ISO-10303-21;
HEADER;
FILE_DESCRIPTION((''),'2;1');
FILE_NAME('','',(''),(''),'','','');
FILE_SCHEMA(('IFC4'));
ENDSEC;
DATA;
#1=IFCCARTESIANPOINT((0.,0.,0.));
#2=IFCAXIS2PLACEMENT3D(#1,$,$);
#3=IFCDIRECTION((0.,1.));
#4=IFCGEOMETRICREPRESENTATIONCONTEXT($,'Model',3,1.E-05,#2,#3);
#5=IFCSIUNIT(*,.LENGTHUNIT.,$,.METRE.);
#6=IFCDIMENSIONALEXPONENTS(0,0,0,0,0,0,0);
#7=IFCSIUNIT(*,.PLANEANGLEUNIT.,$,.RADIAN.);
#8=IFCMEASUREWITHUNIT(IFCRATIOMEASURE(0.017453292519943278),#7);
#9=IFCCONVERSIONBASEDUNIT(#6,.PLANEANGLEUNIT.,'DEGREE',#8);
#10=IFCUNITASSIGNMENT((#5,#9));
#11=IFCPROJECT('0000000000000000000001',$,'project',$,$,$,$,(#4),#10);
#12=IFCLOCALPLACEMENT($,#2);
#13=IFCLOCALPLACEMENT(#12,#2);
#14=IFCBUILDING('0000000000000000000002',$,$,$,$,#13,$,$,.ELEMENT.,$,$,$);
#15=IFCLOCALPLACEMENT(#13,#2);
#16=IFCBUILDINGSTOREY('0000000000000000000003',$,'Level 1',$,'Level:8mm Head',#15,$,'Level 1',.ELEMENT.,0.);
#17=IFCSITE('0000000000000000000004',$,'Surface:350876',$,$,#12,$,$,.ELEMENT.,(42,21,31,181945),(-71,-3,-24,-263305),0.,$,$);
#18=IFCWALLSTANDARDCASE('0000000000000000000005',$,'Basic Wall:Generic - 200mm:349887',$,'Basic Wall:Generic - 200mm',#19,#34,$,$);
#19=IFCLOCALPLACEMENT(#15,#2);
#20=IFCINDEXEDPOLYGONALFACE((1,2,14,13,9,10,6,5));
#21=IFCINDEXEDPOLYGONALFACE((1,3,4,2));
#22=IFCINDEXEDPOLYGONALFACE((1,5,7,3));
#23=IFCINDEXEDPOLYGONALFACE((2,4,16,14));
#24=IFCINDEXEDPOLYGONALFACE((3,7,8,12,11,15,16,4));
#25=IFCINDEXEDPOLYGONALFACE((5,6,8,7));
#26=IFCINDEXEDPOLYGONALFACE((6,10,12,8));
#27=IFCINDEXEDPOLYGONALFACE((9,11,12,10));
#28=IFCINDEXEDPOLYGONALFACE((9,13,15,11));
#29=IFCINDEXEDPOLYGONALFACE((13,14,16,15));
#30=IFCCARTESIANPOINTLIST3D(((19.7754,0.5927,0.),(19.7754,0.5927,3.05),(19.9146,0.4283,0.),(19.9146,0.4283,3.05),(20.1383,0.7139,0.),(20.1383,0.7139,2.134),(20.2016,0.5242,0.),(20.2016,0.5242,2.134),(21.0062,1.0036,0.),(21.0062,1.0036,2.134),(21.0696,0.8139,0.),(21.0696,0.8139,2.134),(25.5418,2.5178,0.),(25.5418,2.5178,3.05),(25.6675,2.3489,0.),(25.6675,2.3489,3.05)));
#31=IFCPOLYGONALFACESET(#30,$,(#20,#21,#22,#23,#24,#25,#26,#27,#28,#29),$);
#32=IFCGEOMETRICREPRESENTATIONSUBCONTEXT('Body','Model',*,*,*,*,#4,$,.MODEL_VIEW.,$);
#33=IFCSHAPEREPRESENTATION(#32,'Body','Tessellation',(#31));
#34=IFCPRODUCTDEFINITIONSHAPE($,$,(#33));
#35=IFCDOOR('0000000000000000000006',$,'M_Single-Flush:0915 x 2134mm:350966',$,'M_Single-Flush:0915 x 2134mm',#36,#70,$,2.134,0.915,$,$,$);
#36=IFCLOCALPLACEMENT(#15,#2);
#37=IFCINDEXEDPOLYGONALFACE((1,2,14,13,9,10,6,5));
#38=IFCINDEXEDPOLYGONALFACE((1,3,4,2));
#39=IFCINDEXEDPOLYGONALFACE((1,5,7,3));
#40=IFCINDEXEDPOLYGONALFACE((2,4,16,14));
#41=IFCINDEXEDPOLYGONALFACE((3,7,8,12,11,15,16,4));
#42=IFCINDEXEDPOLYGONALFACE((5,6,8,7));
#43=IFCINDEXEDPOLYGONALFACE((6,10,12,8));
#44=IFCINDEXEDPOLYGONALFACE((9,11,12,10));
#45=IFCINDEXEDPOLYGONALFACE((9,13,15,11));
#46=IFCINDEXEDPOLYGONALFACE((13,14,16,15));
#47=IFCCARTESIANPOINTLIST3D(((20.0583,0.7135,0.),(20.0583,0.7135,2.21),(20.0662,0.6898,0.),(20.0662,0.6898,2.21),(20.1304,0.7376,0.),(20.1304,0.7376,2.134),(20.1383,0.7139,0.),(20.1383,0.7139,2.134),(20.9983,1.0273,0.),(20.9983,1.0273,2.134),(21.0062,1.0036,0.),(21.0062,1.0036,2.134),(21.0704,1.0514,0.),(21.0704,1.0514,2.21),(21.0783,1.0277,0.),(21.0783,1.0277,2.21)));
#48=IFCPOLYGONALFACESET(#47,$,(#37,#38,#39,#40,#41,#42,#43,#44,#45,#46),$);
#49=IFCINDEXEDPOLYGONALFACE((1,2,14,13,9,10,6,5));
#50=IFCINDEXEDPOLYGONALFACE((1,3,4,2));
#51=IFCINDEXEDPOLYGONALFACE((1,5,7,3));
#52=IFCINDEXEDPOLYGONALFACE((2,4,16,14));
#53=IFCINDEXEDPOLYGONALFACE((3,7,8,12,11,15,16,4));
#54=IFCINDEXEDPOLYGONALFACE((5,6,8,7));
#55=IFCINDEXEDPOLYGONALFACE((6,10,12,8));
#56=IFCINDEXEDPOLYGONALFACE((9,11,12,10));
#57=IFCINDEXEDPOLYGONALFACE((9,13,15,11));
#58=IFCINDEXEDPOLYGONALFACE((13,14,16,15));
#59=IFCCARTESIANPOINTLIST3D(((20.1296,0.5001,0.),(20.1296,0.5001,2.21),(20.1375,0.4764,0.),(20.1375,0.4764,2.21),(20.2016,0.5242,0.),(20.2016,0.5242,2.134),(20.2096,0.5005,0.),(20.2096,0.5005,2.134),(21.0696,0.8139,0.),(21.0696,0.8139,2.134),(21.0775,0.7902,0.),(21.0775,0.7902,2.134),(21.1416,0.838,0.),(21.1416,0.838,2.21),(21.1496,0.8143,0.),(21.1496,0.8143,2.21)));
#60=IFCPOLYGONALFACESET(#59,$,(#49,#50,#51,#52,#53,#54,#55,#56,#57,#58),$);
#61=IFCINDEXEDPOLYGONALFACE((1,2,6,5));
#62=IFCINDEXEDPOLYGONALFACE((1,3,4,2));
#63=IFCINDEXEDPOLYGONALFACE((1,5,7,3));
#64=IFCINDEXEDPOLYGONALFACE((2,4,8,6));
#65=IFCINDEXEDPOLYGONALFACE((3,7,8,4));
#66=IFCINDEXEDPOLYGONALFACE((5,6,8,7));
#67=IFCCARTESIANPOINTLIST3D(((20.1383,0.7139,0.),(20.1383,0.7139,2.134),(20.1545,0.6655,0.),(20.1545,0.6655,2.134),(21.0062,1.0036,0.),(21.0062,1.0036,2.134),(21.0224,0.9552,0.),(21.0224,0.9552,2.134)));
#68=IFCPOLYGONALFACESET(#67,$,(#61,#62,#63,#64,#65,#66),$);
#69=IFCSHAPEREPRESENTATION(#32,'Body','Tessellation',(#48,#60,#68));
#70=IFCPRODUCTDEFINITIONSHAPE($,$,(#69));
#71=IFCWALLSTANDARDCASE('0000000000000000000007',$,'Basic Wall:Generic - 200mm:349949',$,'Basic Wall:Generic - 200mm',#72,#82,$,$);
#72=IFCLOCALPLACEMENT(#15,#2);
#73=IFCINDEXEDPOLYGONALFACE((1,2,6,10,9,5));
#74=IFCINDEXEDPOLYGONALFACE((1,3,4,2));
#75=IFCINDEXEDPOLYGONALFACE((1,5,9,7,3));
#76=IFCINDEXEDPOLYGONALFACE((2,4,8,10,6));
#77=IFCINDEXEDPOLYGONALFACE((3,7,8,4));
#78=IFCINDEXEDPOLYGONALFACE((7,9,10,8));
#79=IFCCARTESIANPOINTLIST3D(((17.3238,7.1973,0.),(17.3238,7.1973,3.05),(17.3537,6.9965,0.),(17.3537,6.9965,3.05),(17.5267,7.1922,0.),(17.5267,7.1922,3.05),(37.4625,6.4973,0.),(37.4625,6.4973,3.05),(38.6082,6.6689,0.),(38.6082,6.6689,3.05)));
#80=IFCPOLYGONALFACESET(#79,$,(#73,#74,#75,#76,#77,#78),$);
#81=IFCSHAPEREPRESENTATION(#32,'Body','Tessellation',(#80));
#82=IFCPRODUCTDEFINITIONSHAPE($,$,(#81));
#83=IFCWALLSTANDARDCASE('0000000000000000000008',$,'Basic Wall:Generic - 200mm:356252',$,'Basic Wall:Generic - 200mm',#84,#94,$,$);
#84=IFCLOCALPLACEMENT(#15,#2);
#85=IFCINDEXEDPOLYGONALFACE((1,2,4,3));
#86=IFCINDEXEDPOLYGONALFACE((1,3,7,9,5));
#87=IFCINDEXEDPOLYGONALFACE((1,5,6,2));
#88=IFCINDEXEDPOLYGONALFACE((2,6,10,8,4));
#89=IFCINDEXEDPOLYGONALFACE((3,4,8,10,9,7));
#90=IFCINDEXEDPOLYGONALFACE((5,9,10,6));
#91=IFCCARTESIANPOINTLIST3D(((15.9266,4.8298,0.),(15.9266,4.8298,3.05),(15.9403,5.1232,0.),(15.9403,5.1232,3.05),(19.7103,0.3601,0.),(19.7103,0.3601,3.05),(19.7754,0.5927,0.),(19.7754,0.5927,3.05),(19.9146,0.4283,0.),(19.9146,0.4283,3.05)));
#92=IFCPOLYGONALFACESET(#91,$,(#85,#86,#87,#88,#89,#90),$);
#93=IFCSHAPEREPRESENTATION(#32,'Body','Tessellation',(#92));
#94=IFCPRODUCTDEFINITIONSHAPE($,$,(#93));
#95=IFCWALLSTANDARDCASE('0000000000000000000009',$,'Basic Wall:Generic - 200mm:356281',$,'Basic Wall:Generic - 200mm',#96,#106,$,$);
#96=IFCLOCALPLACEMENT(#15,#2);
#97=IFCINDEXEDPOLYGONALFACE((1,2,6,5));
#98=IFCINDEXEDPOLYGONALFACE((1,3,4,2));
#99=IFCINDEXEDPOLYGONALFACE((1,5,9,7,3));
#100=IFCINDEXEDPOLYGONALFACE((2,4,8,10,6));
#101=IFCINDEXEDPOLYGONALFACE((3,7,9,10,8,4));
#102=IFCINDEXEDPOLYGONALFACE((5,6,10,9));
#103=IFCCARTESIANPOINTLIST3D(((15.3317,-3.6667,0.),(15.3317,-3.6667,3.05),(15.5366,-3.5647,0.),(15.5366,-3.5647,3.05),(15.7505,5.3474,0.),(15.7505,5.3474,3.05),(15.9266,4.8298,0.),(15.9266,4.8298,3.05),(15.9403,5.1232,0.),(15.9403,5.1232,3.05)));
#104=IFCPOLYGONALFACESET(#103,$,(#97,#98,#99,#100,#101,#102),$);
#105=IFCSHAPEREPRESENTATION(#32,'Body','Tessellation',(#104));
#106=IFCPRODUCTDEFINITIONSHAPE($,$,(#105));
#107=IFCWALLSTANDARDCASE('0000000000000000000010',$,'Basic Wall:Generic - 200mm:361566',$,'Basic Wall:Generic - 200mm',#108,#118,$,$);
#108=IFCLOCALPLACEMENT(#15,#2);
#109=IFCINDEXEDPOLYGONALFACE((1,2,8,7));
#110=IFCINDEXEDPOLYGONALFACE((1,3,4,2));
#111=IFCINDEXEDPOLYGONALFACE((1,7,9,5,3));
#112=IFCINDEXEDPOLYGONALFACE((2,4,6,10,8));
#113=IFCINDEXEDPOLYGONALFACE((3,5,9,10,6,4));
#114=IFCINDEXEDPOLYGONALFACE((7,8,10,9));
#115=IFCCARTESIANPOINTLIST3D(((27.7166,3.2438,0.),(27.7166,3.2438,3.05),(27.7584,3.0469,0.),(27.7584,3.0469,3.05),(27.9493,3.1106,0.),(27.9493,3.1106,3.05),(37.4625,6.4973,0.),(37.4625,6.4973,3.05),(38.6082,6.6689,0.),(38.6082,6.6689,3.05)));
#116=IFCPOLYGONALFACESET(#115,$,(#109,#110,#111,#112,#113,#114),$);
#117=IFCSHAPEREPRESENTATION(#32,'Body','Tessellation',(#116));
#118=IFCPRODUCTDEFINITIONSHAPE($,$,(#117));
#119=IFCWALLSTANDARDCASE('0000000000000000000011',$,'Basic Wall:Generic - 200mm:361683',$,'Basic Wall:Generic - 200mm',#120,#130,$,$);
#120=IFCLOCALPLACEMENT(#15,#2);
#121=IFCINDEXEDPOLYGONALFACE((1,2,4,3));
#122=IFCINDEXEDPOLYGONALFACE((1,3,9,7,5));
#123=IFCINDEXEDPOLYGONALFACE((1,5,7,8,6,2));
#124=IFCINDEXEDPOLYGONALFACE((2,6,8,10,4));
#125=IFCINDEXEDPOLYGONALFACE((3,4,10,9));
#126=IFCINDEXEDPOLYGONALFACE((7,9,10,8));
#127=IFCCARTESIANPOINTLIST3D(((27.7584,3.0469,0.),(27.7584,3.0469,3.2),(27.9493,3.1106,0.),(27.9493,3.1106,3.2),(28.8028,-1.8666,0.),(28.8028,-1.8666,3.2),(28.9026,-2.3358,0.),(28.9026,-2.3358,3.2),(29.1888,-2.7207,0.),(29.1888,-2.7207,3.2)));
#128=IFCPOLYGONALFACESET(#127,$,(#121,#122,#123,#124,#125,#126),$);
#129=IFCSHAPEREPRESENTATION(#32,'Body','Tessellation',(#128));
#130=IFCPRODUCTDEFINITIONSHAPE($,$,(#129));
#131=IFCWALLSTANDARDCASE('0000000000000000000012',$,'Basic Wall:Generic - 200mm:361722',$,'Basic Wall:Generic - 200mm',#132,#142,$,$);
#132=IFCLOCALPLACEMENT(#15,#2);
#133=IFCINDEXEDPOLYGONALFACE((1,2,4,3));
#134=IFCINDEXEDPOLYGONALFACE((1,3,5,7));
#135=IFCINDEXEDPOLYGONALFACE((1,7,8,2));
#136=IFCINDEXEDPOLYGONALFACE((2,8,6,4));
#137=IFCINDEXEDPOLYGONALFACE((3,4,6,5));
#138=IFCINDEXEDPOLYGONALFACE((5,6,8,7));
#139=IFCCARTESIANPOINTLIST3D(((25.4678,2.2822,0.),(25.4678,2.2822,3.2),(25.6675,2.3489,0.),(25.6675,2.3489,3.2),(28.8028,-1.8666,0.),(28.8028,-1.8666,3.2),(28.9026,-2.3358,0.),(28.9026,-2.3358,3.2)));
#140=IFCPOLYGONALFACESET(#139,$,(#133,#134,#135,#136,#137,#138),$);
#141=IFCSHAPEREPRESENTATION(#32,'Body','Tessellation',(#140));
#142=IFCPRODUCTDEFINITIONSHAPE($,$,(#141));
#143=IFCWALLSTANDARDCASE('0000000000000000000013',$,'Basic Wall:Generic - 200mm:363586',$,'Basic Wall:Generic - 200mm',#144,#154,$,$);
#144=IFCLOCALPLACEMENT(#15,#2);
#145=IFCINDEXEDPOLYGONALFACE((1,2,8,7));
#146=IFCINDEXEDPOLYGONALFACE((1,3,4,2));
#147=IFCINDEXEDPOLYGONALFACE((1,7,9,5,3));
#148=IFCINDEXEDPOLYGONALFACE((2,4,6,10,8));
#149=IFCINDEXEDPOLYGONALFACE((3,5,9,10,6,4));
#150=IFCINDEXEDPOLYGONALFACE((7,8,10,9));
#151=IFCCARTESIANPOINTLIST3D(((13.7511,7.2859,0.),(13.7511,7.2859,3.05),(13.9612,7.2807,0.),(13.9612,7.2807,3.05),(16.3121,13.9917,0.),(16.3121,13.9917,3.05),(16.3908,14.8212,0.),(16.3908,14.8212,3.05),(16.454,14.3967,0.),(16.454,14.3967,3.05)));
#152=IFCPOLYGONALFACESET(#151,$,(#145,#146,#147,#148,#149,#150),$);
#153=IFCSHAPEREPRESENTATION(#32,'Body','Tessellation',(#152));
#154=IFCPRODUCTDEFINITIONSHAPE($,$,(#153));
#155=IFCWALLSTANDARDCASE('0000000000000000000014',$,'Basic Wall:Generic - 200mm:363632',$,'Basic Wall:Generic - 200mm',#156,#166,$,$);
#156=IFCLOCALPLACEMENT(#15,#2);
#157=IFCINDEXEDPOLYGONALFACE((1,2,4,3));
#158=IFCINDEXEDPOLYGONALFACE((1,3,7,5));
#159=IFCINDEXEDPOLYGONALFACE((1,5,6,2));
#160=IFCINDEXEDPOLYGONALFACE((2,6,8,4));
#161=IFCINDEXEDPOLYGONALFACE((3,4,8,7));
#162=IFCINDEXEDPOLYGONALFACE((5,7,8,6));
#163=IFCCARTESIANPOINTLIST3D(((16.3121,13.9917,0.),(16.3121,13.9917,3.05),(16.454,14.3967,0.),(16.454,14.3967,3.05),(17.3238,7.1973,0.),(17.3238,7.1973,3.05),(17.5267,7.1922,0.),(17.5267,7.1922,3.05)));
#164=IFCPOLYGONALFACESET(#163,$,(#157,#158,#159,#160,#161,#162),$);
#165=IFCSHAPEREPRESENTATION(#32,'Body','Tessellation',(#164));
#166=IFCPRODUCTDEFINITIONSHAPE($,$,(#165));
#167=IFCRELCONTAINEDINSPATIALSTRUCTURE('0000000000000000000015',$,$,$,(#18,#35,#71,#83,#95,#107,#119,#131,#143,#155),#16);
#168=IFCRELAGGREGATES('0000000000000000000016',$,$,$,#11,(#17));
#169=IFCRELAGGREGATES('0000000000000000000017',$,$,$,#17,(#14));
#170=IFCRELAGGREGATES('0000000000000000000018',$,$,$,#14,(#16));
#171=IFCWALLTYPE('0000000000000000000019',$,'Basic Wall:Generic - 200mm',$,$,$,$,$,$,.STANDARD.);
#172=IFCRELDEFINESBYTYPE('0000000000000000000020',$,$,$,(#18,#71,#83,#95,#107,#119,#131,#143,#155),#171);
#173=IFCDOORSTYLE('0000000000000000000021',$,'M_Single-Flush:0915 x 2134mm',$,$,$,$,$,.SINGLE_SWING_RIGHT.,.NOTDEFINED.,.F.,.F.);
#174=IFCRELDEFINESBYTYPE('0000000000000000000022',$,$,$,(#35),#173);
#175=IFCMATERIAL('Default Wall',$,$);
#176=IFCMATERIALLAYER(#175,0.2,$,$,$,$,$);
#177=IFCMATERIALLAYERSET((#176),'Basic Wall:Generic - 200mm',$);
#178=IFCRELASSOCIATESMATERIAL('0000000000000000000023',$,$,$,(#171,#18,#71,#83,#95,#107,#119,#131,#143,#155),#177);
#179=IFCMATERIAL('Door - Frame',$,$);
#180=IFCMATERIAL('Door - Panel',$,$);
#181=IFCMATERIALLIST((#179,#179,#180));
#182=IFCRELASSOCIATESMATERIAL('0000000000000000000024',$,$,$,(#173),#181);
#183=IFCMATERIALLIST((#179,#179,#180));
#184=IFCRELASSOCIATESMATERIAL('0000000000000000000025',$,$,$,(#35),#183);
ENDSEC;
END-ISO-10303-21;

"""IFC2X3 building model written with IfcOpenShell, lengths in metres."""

from ifc_helpers import new_model, entity, si_unit, converted_unit, direction, frame, frame_2d, origin, place, context, subcontext, project, spatial, polyline, rectangle, outline, extrude, source, transform, mapped, material, material_list, layer, layer_set, layer_usage, type_object, type_shapes, element, fill, save


model = new_model("IFC2X3")

# Units and contexts
model_context = context("Model", 3, precision=1e-05, world=origin(), true_north=direction((0.0, 1.0)))
body_context = subcontext(model_context, "Body", "Model", "MODEL_VIEW")
ifc_project = project(units=[si_unit("LENGTHUNIT", "METRE"), converted_unit("PLANEANGLEUNIT", "DEGREE", entity("IfcRatioMeasure", 0.017453292519943278), si_unit("PLANEANGLEUNIT", "RADIAN"), dimensions=[0, 0, 0, 0, 0, 0, 0])], contexts=[model_context])

# Site, building, storey
site_placement = place(None, origin())
site = spatial("IfcSite", under=ifc_project, at=site_placement, Name="Surface:350876", CompositionType="ELEMENT", RefLatitude=(42, 21, 31, 181945), RefLongitude=(-71, -3, -24, -263305), RefElevation=0.0)
building_placement = place(site_placement, origin())
building = spatial("IfcBuilding", under=site, at=building_placement, CompositionType="ELEMENT")
storey_placement = place(building_placement, origin())
storey = spatial("IfcBuildingStorey", under=building, at=storey_placement, Name="Level 1", ObjectType="Level:8mm Head", LongName="Level 1", CompositionType="ELEMENT", Elevation=0.0)

# Wall, opening, door
ifc_material_1 = material(Name="Default Wall")
ifc_layer_1 = layer(ifc_material_1, 0.2)
ifc_layer_set_1 = layer_set([ifc_layer_1], Name="Basic Wall:Generic - 200mm")
ifc_layer_usage_1 = layer_usage(ifc_layer_set_1, "AXIS2", "NEGATIVE", 0.1)
wall_type_1 = type_object("IfcWallType", Name="Basic Wall:Generic - 200mm", PredefinedType="STANDARD", material=ifc_layer_set_1)
wall_1_placement = place(storey_placement, frame((19.8071, 0.4979, 0.0), z_axis=(0.0, 0.0, 1.0), x_axis=(0.94854, 0.316657, 0.0)))
wall_1 = element("IfcWallStandardCase", 1, at=wall_1_placement, inside=storey, type_object=wall_type_1, material=ifc_layer_usage_1, Name="Basic Wall:Generic - 200mm:349887", ObjectType="Basic Wall:Generic - 200mm", context=body_context, shape_type="SweptSolid", body=[
    extrude(outline(polyline([(0.0799, -0.1), (6.1449, -0.1), (6.0792, 0.1), (0.0, 0.1), (0.0799, -0.1)])), origin(), (0.0, 0.0, 1.0), 3.05),
])
opening_1_placement = place(wall_1_placement, frame((0.3826, -0.1, 0.0)))
opening_1 = element("IfcOpeningElement", 2, at=opening_1_placement, cuts=wall_1, ObjectType="Opening", context=body_context, shape_type="SweptSolid", body=[
    extrude(rectangle(XDim=0.915, YDim=2.134, at=frame_2d((1.067, 0.4575), x_axis=(0.0, 1.0))), frame((0.0, 0.0, 0.0), z_axis=(0.0, 1.0, 0.0), x_axis=(0.0, 0.0, 1.0)), (0.0, 0.0, 1.0), 0.2),
])
ifc_material_2 = material(Name="Door - Frame")
ifc_material_3 = material(Name="Door - Panel")
ifc_material_list_1 = material_list([ifc_material_2, ifc_material_2, ifc_material_3])
ifc_material_list_2 = material_list([ifc_material_2, ifc_material_2, ifc_material_3])
door_style = type_object("IfcDoorStyle", Name="M_Single-Flush:0915 x 2134mm", ConstructionType="NOTDEFINED", OperationType="SINGLE_SWING_RIGHT", ParameterTakesPrecedence=False, Sizeable=False, material=ifc_material_list_2)
shared_shape_1 = source(origin(), body_context, "Body", "SweptSolid", [
    extrude(outline(polyline([(-0.5335, -1.124), (0.5335, -1.124), (0.5335, 1.086), (0.4575, 1.086), (0.4575, -1.048), (-0.4575, -1.048), (-0.4575, 1.086), (-0.5335, 1.086), (-0.5335, -1.124)])), frame((0.4575, 0.2, 1.086), z_axis=(0.0, 1.0, 0.0), x_axis=(1.0, 0.0, 0.0)), (0.0, 0.0, 1.0), 0.025),
    extrude(outline(polyline([(-1.124, -0.5335), (1.086, -0.5335), (1.086, -0.4575), (-1.048, -0.4575), (-1.048, 0.4575), (1.086, 0.4575), (1.086, 0.5335), (-1.124, 0.5335), (-1.124, -0.5335)])), frame((0.4575, -0.025, 1.086), z_axis=(0.0, 1.0, 0.0), x_axis=(0.0, 0.0, -1.0)), (0.0, 0.0, 1.0), 0.025),
    extrude(rectangle(XDim=0.051, YDim=0.915, at=frame_2d((0.0, 0.0), x_axis=(1.0, 0.0))), frame((0.4575, 0.1745, 0.0), z_axis=(0.0, 0.0, 1.0), x_axis=(0.0, 1.0, 0.0)), (0.0, 0.0, 1.0), 2.134),
])
type_shapes(door_style, [shared_shape_1])
door_placement = place(opening_1_placement, origin())
door = element("IfcDoor", 3, at=door_placement, inside=storey, type_object=door_style, material=ifc_material_list_1, Name="M_Single-Flush:0915 x 2134mm:350966", ObjectType="M_Single-Flush:0915 x 2134mm", OverallHeight=2.134, OverallWidth=0.915, context=body_context, shape_type="MappedRepresentation", body=[
    mapped(shared_shape_1, transform((0.0, 0.0, 0.0), scale=1.0)),
])
fill(opening_1, door)

# Walls
ifc_layer_usage_2 = layer_usage(ifc_layer_set_1, "AXIS2", "NEGATIVE", 0.1)
wall_2_placement = place(storey_placement, frame((38.6057, 6.569, 0.0), z_axis=(0.0, 0.0, 1.0), x_axis=(-0.999692, 0.024814, 0.0)))
element("IfcWallStandardCase", 4, at=wall_2_placement, inside=storey, type_object=wall_type_1, material=ifc_layer_usage_2, Name="Basic Wall:Generic - 200mm:349949", ObjectType="Basic Wall:Generic - 200mm", context=body_context, shape_type="SweptSolid", body=[
    extrude(outline(polyline([(21.291, -0.1), (21.2561, 0.1), (1.1411, 0.1), (0.0, -0.1), (21.088, -0.1), (21.291, -0.1)])), origin(), (0.0, 0.0, 1.0), 3.05),
])
ifc_layer_usage_3 = layer_usage(ifc_layer_set_1, "AXIS2", "NEGATIVE", 0.1)
wall_3_placement = place(storey_placement, frame((19.8383, 0.3637, 0.0), z_axis=(0.0, 0.0, 1.0), x_axis=(-0.646106, 0.763247, 0.0)))
element("IfcWallStandardCase", 5, at=wall_3_placement, inside=storey, type_object=wall_type_1, material=ifc_layer_usage_3, Name="Basic Wall:Generic - 200mm:356252", ObjectType="Basic Wall:Generic - 200mm", context=body_context, shape_type="SweptSolid", body=[
    extrude(outline(polyline([(6.1512, -0.1), (5.936, 0.1), (0.0799, 0.1), (0.0, -0.1), (0.2154, -0.1), (6.1512, -0.1)])), origin(), (0.0, 0.0, 1.0), 3.05),
])
ifc_layer_usage_4 = layer_usage(ifc_layer_set_1, "AXIS2", "NEGATIVE", 0.1)
wall_4_placement = place(storey_placement, frame((15.8504, 5.3428, 0.0), z_axis=(0.0, 0.0, 1.0), x_axis=(-0.046409, -0.998923, 0.0)))
element("IfcWallStandardCase", 6, at=wall_4_placement, inside=storey, type_object=wall_type_1, material=ifc_layer_usage_4, Name="Basic Wall:Generic - 200mm:356281", ObjectType="Basic Wall:Generic - 200mm", context=body_context, shape_type="SweptSolid", body=[
    extrude(outline(polyline([(9.0239, -0.1), (8.9125, 0.1), (0.5089, 0.1), (0.2152, 0.1), (0.0, -0.1), (9.0239, -0.1)])), origin(), (0.0, 0.0, 1.0), 3.05),
])
ifc_layer_usage_5 = layer_usage(ifc_layer_set_1, "AXIS2", "NEGATIVE", 0.1)
wall_5_placement = place(storey_placement, frame((27.7268, 3.1417, 0.0), z_axis=(0.0, 0.0, 1.0), x_axis=(0.94854, 0.316657, 0.0)))
element("IfcWallStandardCase", 7, at=wall_5_placement, inside=storey, type_object=wall_type_1, material=ifc_layer_usage_5, Name="Basic Wall:Generic - 200mm:361566", ObjectType="Basic Wall:Generic - 200mm", context=body_context, shape_type="SweptSolid", body=[
    extrude(outline(polyline([(11.4384, -0.1), (10.2973, 0.1), (0.0226, 0.1), (0.0, -0.1), (0.2013, -0.1), (11.4384, -0.1)])), origin(), (0.0, 0.0, 1.0), 3.05),
])
ifc_layer_usage_6 = layer_usage(ifc_layer_set_1, "AXIS2", "POSITIVE", -0.1)
wall_6_placement = place(storey_placement, frame((27.8515, 3.0898, 0.0), z_axis=(0.0, 0.0, 1.0), x_axis=(0.207912, -0.978148, 0.0)))
element("IfcWallStandardCase", 8, at=wall_6_placement, inside=storey, type_object=wall_type_1, material=ifc_layer_usage_6, Name="Basic Wall:Generic - 200mm:361683", ObjectType="Basic Wall:Generic - 200mm", context=body_context, shape_type="SweptSolid", body=[
    extrude(outline(polyline([(5.5256, -0.1), (5.9616, 0.1), (0.0, 0.1), (0.0226, -0.1), (5.0459, -0.1), (5.5256, -0.1)])), origin(), (0.0, 0.0, 1.0), 3.2),
])
ifc_layer_usage_7 = layer_usage(ifc_layer_set_1, "AXIS2", "POSITIVE", -0.1)
wall_7_placement = place(storey_placement, frame((28.9828, -2.2761, 0.0), z_axis=(0.0, 0.0, 1.0), x_axis=(-0.596799, 0.802391, 0.0)))
element("IfcWallStandardCase", 9, at=wall_7_placement, inside=storey, type_object=wall_type_1, material=ifc_layer_usage_7, Name="Basic Wall:Generic - 200mm:361722", ObjectType="Basic Wall:Generic - 200mm", context=body_context, shape_type="SweptSolid", body=[
    extrude(outline(polyline([(5.6896, -0.1), (5.7553, 0.1), (0.0, 0.1), (0.436, -0.1), (5.6896, -0.1)])), origin(), (0.0, 0.0, 1.0), 3.2),
])

# Walls
ifc_layer_usage_8 = layer_usage(ifc_layer_set_1, "AXIS2", "NEGATIVE", 0.1)
wall_8_placement = place(storey_placement, frame((13.8455, 7.2529, 0.0), z_axis=(0.0, 0.0, 1.0), x_axis=(0.330614, 0.943766, 0.0)))
element("IfcWallStandardCase", 10, at=wall_8_placement, inside=storey, type_object=wall_type_1, material=ifc_layer_usage_8, Name="Basic Wall:Generic - 200mm:363586", ObjectType="Basic Wall:Generic - 200mm", context=body_context, shape_type="SweptSolid", body=[
    extrude(outline(polyline([(7.6045, -0.1), (7.9843, 0.1), (0.0, 0.1), (0.0645, -0.1), (7.1753, -0.1), (7.6045, -0.1)])), origin(), (0.0, 0.0, 1.0), 3.05),
])
ifc_layer_usage_9 = layer_usage(ifc_layer_set_1, "AXIS2", "NEGATIVE", 0.1)
wall_9_placement = place(storey_placement, frame((16.3551, 14.382, 0.0), z_axis=(0.0, 0.0, 1.0), x_axis=(0.147268, -0.989097, 0.0)))
element("IfcWallStandardCase", 11, at=wall_9_placement, inside=storey, type_object=wall_type_1, material=ifc_layer_usage_9, Name="Basic Wall:Generic - 200mm:363632", ObjectType="Basic Wall:Generic - 200mm", context=body_context, shape_type="SweptSolid", body=[
    extrude(outline(polyline([(7.249, -0.1), (7.2839, 0.1), (0.0, 0.1), (0.3797, -0.1), (7.249, -0.1)])), origin(), (0.0, 0.0, 1.0), 3.05),
])

save(model, "model.ifc")
